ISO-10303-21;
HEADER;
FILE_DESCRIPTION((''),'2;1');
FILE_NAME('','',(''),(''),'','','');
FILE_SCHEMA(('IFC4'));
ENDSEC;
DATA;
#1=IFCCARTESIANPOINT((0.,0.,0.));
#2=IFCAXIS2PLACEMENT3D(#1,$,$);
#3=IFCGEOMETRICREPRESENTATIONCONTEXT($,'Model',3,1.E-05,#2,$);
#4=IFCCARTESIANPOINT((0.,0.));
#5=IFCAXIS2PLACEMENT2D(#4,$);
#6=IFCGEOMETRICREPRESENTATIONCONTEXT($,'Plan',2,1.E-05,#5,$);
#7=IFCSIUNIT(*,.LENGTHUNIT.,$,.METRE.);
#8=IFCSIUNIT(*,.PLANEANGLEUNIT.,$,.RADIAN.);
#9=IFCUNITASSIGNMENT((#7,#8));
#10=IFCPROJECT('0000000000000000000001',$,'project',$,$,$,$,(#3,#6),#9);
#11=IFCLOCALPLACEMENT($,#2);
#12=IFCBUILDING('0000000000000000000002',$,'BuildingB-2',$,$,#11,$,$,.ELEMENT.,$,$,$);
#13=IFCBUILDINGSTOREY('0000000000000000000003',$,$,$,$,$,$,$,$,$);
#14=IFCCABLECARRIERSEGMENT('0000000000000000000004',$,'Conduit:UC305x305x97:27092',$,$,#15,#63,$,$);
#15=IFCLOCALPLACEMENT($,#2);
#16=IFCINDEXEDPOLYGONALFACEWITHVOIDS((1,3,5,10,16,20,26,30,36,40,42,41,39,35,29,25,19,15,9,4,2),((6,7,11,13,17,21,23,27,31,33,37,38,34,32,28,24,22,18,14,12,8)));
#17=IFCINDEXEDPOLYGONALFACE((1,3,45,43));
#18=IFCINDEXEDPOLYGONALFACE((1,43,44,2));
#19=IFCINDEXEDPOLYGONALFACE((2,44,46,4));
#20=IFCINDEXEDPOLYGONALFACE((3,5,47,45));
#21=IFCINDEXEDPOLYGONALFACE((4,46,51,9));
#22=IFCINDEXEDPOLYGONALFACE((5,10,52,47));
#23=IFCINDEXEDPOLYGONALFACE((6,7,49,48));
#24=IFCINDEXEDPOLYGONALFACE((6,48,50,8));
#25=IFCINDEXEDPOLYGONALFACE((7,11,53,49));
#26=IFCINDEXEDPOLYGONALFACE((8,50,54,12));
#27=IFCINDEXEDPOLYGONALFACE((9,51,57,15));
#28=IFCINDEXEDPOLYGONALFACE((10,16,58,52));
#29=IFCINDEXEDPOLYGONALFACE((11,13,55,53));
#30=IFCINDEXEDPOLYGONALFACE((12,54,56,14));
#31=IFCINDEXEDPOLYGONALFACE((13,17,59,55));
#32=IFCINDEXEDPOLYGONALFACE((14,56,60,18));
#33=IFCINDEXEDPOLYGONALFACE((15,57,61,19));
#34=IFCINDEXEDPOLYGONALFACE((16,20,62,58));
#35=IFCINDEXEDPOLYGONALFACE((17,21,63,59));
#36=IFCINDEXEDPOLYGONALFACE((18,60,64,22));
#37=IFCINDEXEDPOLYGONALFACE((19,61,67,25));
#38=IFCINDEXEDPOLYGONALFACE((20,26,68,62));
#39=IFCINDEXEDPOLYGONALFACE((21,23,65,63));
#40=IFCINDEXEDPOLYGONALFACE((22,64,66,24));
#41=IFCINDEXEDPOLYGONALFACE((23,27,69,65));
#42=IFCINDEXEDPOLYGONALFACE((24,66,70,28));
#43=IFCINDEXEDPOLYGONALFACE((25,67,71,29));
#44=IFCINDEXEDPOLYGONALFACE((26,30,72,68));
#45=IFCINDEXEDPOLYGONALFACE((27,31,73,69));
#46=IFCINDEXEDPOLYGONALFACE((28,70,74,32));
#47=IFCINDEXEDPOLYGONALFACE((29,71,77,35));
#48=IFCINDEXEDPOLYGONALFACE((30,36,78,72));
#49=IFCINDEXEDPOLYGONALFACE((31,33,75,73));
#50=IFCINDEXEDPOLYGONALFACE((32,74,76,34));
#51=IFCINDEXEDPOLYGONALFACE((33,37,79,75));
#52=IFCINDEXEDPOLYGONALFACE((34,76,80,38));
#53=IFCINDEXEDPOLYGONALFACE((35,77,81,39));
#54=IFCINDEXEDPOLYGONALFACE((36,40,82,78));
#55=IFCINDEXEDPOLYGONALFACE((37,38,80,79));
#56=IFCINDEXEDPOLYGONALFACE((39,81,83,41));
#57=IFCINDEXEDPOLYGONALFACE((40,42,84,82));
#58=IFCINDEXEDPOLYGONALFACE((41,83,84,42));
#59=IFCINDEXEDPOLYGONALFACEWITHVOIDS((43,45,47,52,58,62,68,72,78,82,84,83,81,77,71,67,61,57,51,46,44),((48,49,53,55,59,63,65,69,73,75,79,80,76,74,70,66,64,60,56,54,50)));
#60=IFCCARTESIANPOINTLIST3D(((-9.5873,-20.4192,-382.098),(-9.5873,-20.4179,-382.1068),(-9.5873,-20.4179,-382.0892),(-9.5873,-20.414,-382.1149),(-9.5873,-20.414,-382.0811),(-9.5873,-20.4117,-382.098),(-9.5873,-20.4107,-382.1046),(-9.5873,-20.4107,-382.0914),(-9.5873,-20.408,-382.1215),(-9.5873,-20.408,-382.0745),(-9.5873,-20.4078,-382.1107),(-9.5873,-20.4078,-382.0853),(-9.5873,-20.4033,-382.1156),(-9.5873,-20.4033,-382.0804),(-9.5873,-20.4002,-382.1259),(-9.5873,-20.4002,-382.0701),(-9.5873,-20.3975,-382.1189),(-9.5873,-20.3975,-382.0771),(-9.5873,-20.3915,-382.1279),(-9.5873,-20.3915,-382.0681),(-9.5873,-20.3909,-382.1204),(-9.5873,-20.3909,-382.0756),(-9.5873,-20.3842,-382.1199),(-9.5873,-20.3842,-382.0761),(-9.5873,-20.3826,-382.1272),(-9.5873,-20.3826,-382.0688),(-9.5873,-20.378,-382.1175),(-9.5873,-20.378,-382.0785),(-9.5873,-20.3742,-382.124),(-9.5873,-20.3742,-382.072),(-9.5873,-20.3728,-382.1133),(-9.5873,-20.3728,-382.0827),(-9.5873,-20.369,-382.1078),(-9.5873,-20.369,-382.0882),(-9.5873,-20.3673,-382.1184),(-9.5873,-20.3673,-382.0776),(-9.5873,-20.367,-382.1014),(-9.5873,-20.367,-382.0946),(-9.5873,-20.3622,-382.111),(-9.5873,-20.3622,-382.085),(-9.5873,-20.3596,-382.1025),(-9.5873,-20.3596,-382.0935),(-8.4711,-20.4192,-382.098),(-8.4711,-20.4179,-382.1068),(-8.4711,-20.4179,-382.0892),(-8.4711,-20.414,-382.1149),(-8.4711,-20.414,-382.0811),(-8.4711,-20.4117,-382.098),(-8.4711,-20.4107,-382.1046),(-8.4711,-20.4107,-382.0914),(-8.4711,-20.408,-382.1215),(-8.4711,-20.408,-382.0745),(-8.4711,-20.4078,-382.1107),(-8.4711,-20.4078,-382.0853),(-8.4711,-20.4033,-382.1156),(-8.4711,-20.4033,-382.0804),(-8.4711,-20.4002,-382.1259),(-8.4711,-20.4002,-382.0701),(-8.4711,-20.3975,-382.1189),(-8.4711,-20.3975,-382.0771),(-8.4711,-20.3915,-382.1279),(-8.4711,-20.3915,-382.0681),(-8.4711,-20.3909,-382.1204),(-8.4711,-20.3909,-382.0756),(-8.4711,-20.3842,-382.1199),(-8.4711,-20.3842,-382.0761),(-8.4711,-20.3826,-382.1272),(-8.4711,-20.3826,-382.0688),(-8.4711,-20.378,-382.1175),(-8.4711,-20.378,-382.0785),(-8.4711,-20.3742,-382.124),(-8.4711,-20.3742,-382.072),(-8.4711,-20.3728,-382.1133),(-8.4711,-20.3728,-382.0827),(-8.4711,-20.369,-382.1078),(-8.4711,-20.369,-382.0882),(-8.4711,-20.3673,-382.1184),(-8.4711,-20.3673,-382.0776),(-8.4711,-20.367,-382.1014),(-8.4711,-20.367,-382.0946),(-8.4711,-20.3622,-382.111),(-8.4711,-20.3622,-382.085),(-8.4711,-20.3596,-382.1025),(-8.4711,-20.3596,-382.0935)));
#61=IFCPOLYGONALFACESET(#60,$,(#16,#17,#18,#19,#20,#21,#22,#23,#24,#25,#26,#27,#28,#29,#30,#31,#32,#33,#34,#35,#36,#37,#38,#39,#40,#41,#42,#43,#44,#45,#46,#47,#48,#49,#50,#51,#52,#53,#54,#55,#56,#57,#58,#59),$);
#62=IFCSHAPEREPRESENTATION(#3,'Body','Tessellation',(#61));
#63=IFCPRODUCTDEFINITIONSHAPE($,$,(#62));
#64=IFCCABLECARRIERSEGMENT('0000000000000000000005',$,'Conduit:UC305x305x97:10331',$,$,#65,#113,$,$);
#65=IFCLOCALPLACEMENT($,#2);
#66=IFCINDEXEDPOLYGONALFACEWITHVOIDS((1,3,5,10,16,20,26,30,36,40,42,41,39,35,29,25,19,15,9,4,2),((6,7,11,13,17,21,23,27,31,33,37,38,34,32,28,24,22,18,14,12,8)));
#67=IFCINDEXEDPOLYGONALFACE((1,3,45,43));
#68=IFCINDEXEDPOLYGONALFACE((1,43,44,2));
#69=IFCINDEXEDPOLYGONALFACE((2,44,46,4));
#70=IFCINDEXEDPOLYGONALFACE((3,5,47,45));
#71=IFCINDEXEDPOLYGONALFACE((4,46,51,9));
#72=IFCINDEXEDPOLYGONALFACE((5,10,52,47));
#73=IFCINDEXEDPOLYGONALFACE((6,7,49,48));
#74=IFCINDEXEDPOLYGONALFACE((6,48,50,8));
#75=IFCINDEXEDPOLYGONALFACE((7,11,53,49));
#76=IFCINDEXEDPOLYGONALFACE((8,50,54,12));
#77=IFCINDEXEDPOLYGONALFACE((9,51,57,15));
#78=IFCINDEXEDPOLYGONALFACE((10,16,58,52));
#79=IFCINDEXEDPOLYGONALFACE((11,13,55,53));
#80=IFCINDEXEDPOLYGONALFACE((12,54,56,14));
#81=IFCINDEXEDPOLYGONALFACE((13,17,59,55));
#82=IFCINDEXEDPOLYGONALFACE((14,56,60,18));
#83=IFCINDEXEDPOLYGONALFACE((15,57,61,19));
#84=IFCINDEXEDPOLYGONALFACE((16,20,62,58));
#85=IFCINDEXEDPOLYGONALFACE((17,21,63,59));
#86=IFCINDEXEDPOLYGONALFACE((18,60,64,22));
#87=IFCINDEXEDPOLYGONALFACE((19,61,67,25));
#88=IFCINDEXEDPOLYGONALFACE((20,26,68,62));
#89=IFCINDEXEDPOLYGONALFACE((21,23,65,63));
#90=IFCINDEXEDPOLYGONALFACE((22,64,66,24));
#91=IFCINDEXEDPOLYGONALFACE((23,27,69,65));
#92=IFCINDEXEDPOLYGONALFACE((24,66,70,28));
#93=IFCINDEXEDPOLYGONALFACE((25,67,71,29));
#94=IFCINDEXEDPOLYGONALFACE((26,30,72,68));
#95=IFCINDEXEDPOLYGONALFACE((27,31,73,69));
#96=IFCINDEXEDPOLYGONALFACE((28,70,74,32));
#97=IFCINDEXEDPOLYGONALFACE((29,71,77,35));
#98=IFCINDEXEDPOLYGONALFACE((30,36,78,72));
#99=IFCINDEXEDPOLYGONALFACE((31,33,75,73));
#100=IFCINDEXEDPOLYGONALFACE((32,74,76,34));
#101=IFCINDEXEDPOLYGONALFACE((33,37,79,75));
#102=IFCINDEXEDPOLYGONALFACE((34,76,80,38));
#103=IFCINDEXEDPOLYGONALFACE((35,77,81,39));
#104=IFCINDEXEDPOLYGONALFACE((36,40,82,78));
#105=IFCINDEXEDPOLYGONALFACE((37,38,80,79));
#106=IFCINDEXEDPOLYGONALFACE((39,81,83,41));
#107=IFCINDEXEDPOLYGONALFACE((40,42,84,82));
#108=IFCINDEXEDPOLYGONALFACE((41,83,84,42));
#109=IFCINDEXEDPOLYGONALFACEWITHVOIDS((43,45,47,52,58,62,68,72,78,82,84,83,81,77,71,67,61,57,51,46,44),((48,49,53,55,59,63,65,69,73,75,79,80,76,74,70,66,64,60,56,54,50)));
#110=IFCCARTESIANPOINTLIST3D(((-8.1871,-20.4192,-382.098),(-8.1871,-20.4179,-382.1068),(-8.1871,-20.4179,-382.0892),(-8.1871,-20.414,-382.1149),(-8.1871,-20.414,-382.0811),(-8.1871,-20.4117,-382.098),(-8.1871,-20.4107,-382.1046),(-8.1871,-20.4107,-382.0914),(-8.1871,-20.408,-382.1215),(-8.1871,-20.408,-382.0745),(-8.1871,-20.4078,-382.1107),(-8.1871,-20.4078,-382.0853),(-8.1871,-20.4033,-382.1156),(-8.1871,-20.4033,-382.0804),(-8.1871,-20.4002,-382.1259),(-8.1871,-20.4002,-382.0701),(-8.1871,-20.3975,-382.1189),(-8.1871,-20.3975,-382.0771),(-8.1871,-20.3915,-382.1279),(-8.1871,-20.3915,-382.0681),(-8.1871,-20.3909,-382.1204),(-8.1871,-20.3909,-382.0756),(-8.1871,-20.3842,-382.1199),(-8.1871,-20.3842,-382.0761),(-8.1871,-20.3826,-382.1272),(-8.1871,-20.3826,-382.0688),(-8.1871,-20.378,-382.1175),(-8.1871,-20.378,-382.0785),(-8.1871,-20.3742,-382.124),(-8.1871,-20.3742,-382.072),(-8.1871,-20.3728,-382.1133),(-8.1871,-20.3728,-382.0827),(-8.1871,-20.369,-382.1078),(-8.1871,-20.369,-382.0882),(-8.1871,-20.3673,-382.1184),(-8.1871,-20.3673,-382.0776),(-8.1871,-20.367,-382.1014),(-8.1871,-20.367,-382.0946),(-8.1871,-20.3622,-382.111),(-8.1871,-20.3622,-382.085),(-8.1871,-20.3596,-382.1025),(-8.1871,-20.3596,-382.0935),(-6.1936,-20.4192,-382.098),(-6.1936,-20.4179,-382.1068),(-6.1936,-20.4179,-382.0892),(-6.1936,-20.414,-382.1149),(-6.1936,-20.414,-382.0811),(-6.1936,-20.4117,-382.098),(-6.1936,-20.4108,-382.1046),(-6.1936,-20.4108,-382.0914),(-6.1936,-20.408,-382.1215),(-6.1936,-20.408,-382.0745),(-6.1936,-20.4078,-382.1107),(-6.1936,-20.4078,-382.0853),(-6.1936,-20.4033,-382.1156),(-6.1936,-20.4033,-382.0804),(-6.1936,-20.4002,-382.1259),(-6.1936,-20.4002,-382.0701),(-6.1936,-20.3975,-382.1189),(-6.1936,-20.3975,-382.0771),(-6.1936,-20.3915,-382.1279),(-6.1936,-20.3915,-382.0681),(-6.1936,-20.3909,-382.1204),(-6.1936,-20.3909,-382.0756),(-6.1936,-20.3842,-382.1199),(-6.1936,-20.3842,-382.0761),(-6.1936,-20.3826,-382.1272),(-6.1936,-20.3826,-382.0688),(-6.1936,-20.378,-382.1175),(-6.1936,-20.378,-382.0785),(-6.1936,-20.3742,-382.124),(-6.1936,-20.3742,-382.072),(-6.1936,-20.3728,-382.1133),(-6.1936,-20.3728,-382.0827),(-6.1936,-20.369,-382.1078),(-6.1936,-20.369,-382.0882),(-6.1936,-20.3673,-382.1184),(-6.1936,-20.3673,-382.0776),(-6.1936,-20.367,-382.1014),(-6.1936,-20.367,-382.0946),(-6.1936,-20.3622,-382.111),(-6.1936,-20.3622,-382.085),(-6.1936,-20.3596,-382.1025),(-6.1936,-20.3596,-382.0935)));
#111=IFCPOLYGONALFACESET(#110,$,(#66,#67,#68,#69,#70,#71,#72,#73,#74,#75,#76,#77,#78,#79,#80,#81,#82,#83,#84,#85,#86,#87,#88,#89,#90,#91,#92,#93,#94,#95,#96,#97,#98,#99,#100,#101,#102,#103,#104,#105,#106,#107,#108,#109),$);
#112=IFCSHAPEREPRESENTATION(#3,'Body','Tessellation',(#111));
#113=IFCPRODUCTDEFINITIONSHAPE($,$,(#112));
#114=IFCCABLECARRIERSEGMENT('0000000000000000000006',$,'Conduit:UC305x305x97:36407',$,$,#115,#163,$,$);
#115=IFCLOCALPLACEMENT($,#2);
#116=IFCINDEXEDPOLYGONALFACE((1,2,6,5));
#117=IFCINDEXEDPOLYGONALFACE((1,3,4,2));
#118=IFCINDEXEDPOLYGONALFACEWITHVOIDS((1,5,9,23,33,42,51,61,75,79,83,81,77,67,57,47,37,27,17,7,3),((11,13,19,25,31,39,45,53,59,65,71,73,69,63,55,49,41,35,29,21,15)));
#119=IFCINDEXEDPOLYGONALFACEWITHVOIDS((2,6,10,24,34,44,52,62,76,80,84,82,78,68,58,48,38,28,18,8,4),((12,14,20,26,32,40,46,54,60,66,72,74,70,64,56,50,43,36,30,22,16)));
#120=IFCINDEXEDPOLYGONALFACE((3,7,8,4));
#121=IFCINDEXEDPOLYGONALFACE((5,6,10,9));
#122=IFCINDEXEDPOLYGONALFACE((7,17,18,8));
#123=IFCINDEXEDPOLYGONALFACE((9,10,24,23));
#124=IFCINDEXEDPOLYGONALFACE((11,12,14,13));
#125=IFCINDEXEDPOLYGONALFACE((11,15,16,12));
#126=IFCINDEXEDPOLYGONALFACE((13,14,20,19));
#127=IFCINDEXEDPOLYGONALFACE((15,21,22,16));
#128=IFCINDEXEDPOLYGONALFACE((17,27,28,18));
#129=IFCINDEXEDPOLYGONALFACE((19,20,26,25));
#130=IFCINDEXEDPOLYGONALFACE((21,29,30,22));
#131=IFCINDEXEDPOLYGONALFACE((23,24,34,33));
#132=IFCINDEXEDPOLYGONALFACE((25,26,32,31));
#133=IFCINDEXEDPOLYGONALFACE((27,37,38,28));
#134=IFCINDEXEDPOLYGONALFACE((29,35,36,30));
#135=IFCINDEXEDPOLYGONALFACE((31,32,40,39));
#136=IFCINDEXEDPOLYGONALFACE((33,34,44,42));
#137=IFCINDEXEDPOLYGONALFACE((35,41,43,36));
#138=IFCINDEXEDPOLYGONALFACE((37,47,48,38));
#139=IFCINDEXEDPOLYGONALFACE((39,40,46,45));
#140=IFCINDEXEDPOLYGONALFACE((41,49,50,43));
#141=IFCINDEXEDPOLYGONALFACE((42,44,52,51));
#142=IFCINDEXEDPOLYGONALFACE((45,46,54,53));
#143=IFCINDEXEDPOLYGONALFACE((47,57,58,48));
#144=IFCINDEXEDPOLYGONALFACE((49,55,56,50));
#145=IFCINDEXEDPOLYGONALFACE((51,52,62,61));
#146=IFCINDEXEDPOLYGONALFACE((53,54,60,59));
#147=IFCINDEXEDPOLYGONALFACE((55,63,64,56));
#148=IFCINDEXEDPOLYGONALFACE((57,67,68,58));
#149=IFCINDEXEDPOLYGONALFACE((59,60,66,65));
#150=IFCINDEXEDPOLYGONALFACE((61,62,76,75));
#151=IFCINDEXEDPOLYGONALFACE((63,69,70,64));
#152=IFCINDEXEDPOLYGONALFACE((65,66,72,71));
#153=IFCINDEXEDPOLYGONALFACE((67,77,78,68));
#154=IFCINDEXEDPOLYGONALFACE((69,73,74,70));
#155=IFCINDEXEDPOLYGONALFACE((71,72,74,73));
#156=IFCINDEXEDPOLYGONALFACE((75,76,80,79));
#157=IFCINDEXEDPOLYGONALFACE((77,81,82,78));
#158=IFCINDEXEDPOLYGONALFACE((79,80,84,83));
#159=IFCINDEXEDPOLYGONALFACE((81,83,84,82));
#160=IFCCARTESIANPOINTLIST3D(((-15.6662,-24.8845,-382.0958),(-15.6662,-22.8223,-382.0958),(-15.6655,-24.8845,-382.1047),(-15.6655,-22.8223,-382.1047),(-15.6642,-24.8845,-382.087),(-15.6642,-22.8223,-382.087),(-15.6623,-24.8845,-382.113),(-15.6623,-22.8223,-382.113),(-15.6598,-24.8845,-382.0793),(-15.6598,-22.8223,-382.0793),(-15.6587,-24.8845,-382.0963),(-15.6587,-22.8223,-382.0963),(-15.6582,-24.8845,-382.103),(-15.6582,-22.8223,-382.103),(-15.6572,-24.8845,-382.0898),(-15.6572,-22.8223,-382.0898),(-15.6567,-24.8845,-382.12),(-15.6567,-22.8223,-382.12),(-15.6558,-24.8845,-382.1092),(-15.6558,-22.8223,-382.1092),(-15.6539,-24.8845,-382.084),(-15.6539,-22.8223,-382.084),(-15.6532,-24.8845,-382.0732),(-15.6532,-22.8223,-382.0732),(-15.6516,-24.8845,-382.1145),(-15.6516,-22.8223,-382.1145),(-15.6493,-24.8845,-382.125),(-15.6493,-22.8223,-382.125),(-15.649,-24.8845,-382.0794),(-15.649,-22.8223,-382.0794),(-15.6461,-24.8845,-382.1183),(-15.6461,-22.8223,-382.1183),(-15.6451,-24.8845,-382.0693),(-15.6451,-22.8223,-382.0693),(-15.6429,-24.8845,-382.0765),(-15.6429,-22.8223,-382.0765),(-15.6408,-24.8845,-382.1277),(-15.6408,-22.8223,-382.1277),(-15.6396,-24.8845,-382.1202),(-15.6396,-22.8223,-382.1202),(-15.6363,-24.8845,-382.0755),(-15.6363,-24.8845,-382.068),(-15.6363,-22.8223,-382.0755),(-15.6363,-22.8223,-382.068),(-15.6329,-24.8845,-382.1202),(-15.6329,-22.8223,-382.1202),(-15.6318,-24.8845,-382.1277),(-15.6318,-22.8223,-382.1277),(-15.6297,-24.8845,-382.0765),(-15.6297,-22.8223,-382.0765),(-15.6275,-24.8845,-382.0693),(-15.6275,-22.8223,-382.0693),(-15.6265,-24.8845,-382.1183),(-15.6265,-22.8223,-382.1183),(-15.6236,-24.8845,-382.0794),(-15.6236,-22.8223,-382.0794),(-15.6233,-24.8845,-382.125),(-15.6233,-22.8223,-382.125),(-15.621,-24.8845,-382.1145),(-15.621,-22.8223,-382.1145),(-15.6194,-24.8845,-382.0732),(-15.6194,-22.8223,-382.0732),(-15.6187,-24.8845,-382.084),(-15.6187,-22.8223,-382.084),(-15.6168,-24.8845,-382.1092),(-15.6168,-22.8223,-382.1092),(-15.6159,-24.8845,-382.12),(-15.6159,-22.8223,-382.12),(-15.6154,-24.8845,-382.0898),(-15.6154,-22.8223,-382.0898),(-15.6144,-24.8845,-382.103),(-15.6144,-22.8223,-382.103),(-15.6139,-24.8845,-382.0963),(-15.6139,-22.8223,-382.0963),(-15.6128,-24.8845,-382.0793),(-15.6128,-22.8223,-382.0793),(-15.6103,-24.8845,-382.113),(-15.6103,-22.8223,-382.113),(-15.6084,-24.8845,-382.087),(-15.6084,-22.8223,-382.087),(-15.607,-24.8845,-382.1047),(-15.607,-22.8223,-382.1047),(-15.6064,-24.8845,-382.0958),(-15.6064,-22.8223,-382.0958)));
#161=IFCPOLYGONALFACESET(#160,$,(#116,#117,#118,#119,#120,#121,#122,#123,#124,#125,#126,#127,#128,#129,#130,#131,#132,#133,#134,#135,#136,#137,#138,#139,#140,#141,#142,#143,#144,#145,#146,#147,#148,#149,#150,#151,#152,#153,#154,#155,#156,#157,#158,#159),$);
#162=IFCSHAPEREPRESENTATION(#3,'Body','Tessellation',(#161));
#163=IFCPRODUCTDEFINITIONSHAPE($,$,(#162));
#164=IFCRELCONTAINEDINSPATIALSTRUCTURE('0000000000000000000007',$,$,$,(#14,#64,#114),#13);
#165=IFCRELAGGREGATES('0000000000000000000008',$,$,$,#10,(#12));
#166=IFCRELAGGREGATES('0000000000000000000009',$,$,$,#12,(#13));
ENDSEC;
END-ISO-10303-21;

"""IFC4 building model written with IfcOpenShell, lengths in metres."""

from ifc_helpers import new_model, entity, si_unit, origin, origin_2d, place, context, project, spatial, element, save


model = new_model("IFC4")

# Units and contexts
model_context = context("Model", 3, precision=1e-05, world=origin())
plan_context = context("Plan", 2, precision=1e-05, world=origin_2d())
ifc_project = project(units=[si_unit("LENGTHUNIT", "METRE"), si_unit("PLANEANGLEUNIT", "RADIAN")], contexts=[model_context, plan_context])

# Building, storey
building_placement = place(None, origin())
building = spatial("IfcBuilding", under=ifc_project, at=building_placement, Name="BuildingB-2", CompositionType="ELEMENT")
storey = spatial("IfcBuildingStorey", under=building)

# Cable carrier segments
element("IfcCableCarrierSegment", 1, inside=storey, Name="Conduit:UC305x305x97:27092", context=model_context, shape_type="AdvancedSweptSolid", body=[
    entity("IfcSweptDiskSolid", entity("IfcCompositeCurve", [entity("IfcCompositeCurveSegment", "CONTINUOUS", False, entity("IfcPolyline", [entity("IfcCartesianPoint", [9.5873, 20.3892, 382.098]), entity("IfcCartesianPoint", [8.4711, 20.3892, 382.098])]))], False), 0.03, 0.0225),
])
element("IfcCableCarrierSegment", 2, inside=storey, Name="Conduit:UC305x305x97:10331", context=model_context, shape_type="AdvancedSweptSolid", body=[
    entity("IfcSweptDiskSolid", entity("IfcCompositeCurve", [entity("IfcCompositeCurveSegment", "CONTINUOUS", False, entity("IfcPolyline", [entity("IfcCartesianPoint", [8.1871, 20.3892, 382.098]), entity("IfcCartesianPoint", [6.1936, 20.3892, 382.098])]))], False), 0.03, 0.0225),
])
element("IfcCableCarrierSegment", 3, inside=storey, Name="Conduit:UC305x305x97:36407", context=model_context, shape_type="AdvancedSweptSolid", body=[
    entity("IfcSweptDiskSolid", entity("IfcCompositeCurve", [entity("IfcCompositeCurveSegment", "CONTINUOUS", False, entity("IfcPolyline", [entity("IfcCartesianPoint", [15.6363, 22.8223, 382.098]), entity("IfcCartesianPoint", [15.6363, 24.8845, 382.098])]))], False), 0.03, 0.0225),
])

save(model, "model.ifc")
